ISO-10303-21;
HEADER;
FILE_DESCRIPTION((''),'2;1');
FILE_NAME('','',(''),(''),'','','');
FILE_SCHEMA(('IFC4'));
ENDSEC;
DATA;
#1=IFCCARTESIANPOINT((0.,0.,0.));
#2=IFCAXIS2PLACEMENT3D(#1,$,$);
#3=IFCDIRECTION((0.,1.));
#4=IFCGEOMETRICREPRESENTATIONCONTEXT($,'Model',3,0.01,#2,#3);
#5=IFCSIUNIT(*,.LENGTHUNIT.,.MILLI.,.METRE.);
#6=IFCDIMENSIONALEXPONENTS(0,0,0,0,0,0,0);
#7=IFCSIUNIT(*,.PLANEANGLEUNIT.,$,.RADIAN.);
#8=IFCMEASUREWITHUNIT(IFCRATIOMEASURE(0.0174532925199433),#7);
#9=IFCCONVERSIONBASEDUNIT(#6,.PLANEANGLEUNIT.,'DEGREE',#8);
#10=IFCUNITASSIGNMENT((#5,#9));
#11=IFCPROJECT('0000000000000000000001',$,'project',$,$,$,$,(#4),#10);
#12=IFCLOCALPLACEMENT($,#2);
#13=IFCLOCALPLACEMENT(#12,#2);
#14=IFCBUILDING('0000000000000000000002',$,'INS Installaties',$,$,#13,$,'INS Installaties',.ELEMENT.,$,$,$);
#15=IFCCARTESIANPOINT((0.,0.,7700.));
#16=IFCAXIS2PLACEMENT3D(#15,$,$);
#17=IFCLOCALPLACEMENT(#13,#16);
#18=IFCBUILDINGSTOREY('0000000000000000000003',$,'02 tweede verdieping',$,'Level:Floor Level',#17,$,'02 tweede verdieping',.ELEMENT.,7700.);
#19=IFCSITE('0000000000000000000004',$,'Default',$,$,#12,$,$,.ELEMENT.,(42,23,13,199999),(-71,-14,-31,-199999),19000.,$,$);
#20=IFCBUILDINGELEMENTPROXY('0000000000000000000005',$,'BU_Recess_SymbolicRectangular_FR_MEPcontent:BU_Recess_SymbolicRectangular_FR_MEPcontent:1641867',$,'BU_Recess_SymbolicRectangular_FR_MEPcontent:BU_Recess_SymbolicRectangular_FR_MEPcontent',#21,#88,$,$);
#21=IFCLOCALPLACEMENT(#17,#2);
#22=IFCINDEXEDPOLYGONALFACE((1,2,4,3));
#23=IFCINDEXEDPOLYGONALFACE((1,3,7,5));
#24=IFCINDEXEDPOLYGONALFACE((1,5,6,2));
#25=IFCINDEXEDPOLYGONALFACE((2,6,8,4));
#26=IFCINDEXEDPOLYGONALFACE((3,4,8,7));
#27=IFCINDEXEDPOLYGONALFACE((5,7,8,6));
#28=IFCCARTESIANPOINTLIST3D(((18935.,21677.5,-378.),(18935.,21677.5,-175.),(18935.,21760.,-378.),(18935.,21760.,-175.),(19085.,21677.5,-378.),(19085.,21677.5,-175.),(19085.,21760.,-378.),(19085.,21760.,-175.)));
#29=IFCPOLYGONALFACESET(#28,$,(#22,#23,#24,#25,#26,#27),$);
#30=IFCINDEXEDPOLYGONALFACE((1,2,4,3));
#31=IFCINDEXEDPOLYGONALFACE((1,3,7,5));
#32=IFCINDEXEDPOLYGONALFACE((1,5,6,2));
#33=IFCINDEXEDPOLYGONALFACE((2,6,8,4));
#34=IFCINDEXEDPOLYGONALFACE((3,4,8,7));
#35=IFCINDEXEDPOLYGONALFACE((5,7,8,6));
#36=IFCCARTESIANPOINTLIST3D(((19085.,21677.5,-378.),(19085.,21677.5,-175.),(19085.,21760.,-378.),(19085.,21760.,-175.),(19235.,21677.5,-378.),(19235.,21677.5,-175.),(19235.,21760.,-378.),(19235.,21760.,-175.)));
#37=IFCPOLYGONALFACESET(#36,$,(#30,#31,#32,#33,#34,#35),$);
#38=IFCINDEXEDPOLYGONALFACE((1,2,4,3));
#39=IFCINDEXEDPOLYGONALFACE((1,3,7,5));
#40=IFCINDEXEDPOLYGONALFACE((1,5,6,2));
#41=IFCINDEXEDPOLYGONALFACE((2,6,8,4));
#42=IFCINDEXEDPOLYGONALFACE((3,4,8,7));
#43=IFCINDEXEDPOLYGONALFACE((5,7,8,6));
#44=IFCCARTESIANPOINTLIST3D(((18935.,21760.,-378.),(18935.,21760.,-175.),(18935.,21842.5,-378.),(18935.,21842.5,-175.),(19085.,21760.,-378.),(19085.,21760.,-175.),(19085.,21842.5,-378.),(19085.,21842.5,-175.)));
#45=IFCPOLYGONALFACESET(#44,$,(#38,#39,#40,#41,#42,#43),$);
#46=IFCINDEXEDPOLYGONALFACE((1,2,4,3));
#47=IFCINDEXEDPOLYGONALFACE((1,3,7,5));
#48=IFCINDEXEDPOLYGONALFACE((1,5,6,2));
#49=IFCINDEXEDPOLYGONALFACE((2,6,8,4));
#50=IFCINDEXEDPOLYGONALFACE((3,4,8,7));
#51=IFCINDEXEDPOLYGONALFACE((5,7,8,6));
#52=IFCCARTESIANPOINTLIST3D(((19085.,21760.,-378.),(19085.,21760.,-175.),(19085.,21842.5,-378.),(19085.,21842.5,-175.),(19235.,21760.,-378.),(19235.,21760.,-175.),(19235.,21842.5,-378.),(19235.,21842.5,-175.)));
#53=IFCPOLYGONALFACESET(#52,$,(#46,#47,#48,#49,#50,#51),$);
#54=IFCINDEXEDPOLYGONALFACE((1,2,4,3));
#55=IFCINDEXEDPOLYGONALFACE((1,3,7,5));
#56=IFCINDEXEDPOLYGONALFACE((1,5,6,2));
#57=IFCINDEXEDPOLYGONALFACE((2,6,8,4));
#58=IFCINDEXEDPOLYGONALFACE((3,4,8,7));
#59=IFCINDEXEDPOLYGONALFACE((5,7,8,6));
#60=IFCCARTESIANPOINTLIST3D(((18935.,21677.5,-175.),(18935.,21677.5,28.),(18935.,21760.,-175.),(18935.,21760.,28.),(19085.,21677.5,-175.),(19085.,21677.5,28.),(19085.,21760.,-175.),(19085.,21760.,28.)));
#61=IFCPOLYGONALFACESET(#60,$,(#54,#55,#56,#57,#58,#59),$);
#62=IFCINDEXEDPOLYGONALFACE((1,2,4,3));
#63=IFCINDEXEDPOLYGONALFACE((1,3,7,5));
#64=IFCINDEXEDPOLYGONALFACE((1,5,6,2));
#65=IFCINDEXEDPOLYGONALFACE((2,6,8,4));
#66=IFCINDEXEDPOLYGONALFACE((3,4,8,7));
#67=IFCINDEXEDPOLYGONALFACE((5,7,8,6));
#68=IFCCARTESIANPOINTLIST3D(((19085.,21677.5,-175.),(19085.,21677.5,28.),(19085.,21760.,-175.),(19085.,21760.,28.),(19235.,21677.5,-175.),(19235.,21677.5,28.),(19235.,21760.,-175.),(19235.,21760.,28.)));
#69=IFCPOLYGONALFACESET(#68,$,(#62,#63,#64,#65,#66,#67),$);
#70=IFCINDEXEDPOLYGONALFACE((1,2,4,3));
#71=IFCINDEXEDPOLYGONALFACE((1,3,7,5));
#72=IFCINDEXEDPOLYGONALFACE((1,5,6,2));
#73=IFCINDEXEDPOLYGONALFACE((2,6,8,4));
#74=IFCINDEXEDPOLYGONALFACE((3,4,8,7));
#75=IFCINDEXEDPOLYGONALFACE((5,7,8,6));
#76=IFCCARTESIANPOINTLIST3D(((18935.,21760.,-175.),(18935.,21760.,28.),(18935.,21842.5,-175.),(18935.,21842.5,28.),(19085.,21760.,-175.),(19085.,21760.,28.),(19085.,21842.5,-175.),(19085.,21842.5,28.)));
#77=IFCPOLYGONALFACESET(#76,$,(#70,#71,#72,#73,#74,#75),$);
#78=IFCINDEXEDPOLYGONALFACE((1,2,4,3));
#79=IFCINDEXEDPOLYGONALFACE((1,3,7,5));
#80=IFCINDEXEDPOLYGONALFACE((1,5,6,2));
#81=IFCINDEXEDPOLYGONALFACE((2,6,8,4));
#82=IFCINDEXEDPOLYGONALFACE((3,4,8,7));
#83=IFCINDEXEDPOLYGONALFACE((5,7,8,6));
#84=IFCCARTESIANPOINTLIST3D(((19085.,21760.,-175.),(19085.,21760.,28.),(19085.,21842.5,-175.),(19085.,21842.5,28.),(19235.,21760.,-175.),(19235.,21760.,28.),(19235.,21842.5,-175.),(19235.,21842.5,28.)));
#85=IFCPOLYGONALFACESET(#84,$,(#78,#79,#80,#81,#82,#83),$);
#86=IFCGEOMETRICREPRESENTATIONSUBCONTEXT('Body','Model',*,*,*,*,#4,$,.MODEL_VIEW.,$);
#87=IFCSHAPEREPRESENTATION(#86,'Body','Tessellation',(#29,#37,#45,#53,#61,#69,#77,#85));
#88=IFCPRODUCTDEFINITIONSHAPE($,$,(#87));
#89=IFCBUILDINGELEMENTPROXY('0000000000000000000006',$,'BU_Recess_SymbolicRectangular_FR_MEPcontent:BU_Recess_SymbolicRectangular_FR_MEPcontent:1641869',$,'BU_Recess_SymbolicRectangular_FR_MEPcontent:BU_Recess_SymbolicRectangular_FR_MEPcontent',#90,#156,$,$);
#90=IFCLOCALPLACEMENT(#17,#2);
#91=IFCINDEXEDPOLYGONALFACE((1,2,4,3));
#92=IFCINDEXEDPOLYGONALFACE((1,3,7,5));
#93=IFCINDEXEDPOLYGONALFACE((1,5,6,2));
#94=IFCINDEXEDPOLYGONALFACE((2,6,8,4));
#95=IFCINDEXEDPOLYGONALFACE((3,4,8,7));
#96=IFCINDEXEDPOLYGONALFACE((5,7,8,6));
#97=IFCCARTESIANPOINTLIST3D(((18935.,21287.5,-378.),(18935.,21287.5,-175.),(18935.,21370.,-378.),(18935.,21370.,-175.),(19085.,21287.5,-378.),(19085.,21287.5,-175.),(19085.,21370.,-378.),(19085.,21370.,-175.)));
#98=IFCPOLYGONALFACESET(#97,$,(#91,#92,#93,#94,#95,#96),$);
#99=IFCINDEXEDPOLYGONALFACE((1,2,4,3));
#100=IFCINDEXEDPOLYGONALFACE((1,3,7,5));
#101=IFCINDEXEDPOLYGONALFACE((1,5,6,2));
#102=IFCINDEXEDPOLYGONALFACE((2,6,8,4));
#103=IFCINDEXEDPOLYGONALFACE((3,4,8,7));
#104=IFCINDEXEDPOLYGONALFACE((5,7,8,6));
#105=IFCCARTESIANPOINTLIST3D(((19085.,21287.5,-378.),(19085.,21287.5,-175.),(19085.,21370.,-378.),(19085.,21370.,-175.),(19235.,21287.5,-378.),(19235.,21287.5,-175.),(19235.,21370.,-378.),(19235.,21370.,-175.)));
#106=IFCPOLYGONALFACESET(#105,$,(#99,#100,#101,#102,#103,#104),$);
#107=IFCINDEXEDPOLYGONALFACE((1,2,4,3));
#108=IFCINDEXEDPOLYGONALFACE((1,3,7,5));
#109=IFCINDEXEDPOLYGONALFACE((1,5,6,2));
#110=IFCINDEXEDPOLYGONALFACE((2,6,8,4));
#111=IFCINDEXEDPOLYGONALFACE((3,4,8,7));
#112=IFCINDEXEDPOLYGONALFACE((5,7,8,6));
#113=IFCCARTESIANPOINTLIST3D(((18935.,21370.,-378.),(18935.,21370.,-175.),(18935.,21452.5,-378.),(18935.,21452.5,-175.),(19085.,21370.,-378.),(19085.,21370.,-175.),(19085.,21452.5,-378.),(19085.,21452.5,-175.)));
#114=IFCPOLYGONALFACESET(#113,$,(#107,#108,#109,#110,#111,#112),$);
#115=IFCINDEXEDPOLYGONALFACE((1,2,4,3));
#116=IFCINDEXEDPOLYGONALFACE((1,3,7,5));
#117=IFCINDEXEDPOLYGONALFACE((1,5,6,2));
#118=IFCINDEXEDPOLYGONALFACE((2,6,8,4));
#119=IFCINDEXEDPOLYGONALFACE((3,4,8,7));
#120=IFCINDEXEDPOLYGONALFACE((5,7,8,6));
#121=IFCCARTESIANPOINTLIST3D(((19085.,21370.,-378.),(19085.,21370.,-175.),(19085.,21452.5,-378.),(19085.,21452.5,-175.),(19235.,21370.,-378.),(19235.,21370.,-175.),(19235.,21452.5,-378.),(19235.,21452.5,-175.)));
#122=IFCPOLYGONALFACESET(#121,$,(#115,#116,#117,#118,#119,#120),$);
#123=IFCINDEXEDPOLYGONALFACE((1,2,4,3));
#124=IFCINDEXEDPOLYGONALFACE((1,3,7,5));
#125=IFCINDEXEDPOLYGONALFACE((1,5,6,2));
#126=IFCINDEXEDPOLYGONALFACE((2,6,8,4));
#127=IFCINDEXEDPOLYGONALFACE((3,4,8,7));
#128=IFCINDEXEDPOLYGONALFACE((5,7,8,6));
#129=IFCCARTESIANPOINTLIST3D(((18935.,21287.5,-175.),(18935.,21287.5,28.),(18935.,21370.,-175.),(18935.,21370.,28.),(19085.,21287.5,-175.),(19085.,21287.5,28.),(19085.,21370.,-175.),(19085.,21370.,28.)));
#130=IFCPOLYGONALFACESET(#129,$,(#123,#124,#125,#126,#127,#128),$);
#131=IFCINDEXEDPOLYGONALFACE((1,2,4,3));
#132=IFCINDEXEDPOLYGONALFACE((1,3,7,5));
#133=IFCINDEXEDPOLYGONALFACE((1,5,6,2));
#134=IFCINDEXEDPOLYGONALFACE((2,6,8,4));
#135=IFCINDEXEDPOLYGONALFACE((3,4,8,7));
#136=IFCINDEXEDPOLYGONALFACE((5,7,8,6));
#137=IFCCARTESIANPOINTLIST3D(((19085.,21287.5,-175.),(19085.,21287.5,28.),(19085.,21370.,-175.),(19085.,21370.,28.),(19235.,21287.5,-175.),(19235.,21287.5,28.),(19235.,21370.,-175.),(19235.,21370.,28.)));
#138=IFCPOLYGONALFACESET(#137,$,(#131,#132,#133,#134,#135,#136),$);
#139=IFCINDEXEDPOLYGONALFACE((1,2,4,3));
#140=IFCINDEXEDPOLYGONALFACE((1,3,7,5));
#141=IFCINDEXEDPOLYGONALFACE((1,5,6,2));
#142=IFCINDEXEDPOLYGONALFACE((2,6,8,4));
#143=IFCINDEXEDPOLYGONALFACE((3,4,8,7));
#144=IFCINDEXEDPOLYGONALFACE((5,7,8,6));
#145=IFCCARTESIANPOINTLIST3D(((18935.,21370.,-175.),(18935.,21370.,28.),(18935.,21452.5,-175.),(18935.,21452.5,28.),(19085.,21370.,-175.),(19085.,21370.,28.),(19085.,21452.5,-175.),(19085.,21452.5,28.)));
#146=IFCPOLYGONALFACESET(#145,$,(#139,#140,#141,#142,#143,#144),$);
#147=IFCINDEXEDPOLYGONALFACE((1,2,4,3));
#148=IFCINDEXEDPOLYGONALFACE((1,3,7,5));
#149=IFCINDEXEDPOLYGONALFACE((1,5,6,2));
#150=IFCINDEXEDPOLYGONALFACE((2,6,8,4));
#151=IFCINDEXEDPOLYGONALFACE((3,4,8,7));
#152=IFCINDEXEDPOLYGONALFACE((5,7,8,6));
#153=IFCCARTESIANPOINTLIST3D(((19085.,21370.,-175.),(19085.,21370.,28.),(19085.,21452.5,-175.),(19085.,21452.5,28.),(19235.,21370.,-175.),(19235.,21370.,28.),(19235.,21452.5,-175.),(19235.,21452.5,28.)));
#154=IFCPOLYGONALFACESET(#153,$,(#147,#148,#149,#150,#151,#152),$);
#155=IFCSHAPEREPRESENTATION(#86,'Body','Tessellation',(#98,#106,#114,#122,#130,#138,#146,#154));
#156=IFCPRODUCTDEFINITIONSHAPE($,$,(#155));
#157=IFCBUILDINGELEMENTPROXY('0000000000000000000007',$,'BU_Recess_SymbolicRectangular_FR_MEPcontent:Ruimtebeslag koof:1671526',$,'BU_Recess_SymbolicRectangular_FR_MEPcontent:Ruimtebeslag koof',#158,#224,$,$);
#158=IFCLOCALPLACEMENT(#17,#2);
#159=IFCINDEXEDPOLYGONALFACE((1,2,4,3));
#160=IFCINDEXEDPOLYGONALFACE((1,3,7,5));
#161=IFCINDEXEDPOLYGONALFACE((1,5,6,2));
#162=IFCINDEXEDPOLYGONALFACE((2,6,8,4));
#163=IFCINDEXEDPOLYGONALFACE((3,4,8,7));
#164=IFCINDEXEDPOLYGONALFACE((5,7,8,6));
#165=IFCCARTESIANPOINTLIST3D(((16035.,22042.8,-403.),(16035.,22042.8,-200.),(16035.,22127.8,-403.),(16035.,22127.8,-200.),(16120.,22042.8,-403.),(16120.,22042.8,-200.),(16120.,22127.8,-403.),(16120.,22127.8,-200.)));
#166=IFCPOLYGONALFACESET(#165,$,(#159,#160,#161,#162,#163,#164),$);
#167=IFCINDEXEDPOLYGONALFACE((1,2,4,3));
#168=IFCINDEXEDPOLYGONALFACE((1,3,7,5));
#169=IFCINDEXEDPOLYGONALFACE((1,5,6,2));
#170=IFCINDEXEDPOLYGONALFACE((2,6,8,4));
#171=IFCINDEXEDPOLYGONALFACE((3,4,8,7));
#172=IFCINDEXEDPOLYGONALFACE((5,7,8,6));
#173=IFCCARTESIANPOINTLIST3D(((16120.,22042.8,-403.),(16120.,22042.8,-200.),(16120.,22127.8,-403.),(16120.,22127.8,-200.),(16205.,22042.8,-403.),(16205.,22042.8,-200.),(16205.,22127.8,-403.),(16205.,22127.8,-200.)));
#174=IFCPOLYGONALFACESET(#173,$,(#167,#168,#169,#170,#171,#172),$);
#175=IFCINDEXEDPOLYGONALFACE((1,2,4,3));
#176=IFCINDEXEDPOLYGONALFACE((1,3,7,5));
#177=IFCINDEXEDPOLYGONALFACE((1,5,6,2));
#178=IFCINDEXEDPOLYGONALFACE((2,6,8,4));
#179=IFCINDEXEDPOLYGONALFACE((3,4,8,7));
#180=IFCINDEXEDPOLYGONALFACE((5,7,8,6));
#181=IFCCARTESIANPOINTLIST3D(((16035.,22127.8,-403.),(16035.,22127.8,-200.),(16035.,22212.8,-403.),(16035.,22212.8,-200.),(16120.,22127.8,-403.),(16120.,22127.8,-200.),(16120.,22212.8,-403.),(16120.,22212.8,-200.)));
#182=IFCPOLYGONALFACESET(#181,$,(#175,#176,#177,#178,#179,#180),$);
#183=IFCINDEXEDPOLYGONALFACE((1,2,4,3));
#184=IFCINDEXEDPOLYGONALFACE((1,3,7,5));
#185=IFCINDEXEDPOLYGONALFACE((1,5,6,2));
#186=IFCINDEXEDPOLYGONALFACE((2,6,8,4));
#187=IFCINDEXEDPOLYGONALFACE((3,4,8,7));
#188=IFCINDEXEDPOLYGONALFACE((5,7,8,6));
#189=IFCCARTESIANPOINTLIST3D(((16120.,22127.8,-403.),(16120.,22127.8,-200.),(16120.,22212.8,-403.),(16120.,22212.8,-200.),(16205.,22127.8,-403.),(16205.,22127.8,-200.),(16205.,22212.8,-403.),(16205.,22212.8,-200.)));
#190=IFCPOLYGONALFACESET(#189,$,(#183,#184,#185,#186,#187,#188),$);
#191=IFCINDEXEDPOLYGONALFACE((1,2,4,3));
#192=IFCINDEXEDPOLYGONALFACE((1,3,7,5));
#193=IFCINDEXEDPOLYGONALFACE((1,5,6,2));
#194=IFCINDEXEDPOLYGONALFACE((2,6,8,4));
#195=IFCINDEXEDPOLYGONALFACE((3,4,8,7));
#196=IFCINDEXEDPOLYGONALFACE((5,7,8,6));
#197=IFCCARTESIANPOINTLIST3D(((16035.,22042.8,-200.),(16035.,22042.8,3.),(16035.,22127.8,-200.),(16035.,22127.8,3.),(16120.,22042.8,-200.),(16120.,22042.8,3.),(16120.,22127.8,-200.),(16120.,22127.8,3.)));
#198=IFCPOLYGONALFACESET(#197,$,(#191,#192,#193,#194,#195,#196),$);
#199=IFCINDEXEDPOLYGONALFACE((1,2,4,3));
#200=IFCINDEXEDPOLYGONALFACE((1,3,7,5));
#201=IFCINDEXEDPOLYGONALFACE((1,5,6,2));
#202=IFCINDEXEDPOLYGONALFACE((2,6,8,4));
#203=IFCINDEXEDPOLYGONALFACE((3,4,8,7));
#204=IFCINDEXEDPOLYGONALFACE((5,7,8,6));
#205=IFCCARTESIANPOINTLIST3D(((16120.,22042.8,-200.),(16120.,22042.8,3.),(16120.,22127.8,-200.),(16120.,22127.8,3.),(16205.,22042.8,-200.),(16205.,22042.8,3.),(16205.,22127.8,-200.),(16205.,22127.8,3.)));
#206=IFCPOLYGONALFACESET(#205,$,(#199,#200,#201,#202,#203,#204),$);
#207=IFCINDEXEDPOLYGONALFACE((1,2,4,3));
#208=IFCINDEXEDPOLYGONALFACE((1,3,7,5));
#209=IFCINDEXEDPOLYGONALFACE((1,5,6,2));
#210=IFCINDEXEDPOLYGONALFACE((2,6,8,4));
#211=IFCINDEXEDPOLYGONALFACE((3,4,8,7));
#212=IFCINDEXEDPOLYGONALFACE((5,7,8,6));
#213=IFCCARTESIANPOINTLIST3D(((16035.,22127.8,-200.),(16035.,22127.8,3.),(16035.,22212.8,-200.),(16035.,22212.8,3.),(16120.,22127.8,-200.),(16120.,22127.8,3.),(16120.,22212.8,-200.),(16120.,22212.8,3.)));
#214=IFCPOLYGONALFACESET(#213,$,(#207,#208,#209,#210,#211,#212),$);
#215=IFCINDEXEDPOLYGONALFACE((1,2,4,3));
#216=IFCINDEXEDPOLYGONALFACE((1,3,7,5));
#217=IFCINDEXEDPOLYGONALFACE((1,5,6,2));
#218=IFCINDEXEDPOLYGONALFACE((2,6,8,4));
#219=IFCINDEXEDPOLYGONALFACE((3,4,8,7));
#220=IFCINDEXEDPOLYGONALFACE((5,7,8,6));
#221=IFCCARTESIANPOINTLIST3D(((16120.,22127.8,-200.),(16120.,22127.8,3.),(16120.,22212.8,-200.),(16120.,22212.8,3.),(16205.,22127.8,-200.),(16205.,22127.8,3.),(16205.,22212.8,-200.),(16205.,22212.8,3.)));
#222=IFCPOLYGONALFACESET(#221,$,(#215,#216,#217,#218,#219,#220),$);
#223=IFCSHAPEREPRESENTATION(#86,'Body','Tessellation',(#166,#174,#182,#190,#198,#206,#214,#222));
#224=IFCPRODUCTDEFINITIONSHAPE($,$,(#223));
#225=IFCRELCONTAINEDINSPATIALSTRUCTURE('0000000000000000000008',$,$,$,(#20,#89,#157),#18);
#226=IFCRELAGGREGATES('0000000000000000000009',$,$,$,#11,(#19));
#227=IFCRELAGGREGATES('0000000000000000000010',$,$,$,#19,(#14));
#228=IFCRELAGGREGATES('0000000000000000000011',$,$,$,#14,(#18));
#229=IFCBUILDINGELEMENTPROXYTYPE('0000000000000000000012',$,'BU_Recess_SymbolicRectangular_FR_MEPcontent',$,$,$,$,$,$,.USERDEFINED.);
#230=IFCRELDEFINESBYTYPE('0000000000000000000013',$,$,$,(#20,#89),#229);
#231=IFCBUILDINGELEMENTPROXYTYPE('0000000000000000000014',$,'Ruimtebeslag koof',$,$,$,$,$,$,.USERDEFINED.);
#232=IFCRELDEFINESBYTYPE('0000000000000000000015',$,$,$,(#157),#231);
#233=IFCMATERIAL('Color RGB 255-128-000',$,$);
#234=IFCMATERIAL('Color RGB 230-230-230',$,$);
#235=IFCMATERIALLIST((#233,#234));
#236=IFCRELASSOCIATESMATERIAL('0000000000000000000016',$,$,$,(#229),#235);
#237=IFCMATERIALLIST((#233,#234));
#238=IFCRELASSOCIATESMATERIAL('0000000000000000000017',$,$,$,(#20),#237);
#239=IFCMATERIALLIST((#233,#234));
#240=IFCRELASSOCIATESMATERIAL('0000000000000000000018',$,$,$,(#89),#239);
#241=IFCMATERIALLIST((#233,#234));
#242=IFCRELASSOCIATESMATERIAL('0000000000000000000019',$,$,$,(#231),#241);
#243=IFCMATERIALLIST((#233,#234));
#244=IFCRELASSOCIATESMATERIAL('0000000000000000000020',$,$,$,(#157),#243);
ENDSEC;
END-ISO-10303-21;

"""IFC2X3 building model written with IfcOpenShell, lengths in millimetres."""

from ifc_helpers import new_model, entity, si_unit, converted_unit, direction, frame, frame_2d, origin, origin_2d_with_axis, place, context, subcontext, project, spatial, rectangle, extrude, source, transform, mapped, material, material_list, type_object, type_shapes, element, save


model = new_model("IFC2X3")

# Units and contexts
model_context = context("Model", 3, precision=0.01, world=origin(), true_north=direction((0.0, 1.0)))
body_context = subcontext(model_context, "Body", "Model", "MODEL_VIEW")
ifc_project = project(units=[si_unit("LENGTHUNIT", "METRE", prefix="MILLI"), converted_unit("PLANEANGLEUNIT", "DEGREE", entity("IfcRatioMeasure", 0.0174532925199433), si_unit("PLANEANGLEUNIT", "RADIAN"), dimensions=[0, 0, 0, 0, 0, 0, 0])], contexts=[model_context])

# Site, building, storey
site_placement = place(None, origin())
site = spatial("IfcSite", under=ifc_project, at=site_placement, Name="Default", CompositionType="ELEMENT", RefLatitude=(42, 23, 13, 199999), RefLongitude=(-71, -14, -31, -199999), RefElevation=19000.0)
building_placement = place(site_placement, origin())
building = spatial("IfcBuilding", under=site, at=building_placement, Name="INS Installaties", LongName="INS Installaties", CompositionType="ELEMENT")
storey_placement = place(building_placement, frame((0.0, 0.0, 7700.0)))
storey = spatial("IfcBuildingStorey", under=building, at=storey_placement, Name="02 tweede verdieping", ObjectType="Level:Floor Level", LongName="02 tweede verdieping", CompositionType="ELEMENT", Elevation=7700.0)

# Building element proxies
ifc_material_1 = material(Name="Color RGB 255-128-000")
ifc_material_2 = material(Name="Color RGB 230-230-230")
ifc_material_list_1 = material_list([ifc_material_1, ifc_material_2])
ifc_material_list_2 = material_list([ifc_material_1, ifc_material_2])
building_element_proxy_type_1 = type_object("IfcBuildingElementProxyType", Name="BU_Recess_SymbolicRectangular_FR_MEPcontent", PredefinedType="USERDEFINED", material=ifc_material_list_2)
shared_shape_1 = source(origin(), body_context, "Body", "SweptSolid", [
    extrude(rectangle(XDim=82.5, YDim=150.0, at=origin_2d_with_axis()), frame((75.0, 41.2, -403.0), z_axis=(0.0, 0.0, 1.0), x_axis=(0.0, -1.0, 0.0)), (0.0, 0.0, 1.0), 203.0),
    extrude(rectangle(XDim=150.0, YDim=82.5, at=frame_2d((0.0, 0.0), x_axis=(1.0, 0.0))), frame((-75.0, 41.2, -403.0), z_axis=(0.0, 0.0, 1.0), x_axis=(-1.0, 0.0, 0.0)), (0.0, 0.0, 1.0), 203.0),
    extrude(rectangle(XDim=150.0, YDim=82.5, at=frame_2d((0.0, 0.0), x_axis=(1.0, 0.0))), frame((75.0, -41.3, -403.0)), (0.0, 0.0, 1.0), 203.0),
    extrude(rectangle(XDim=82.5, YDim=150.0, at=origin_2d_with_axis()), frame((-75.0, -41.3, -403.0), z_axis=(0.0, 0.0, 1.0), x_axis=(0.0, 1.0, 0.0)), (0.0, 0.0, 1.0), 203.0),
    extrude(rectangle(XDim=82.5, YDim=150.0, at=origin_2d_with_axis()), frame((75.0, 41.3, -200.0), z_axis=(0.0, 0.0, 1.0), x_axis=(0.0, -1.0, 0.0)), (0.0, 0.0, 1.0), 203.0),
    extrude(rectangle(XDim=150.0, YDim=82.5, at=frame_2d((0.0, 0.0), x_axis=(1.0, 0.0))), frame((-75.0, 41.3, -200.0), z_axis=(0.0, 0.0, 1.0), x_axis=(-1.0, 0.0, 0.0)), (0.0, 0.0, 1.0), 203.0),
    extrude(rectangle(XDim=150.0, YDim=82.5, at=frame_2d((0.0, 0.0), x_axis=(1.0, 0.0))), frame((75.0, -41.2, -200.0)), (0.0, 0.0, 1.0), 203.0),
    extrude(rectangle(XDim=82.5, YDim=150.0, at=origin_2d_with_axis()), frame((-75.0, -41.2, -200.0), z_axis=(0.0, 0.0, 1.0), x_axis=(0.0, 1.0, 0.0)), (0.0, 0.0, 1.0), 203.0),
])
type_shapes(building_element_proxy_type_1, [shared_shape_1])
proxy_1_placement = place(storey_placement, frame((19085.0, 21760.0, 25.0), z_axis=(0.0, 0.0, 1.0), x_axis=(-1.0, 0.0, 0.0)))
element("IfcBuildingElementProxy", 1, at=proxy_1_placement, inside=storey, type_object=building_element_proxy_type_1, material=ifc_material_list_1, Name="BU_Recess_SymbolicRectangular_FR_MEPcontent:BU_Recess_SymbolicRectangular_FR_MEPcontent:1641867", ObjectType="BU_Recess_SymbolicRectangular_FR_MEPcontent:BU_Recess_SymbolicRectangular_FR_MEPcontent", context=body_context, shape_type="MappedRepresentation", body=[
    mapped(shared_shape_1, transform((0.0, 0.0, 0.0), scale=1.0)),
])
ifc_material_list_3 = material_list([ifc_material_1, ifc_material_2])
proxy_2_placement = place(storey_placement, frame((19085.0, 21370.0, 25.0), z_axis=(0.0, 0.0, 1.0), x_axis=(-1.0, 0.0, 0.0)))
element("IfcBuildingElementProxy", 2, at=proxy_2_placement, inside=storey, type_object=building_element_proxy_type_1, material=ifc_material_list_3, Name="BU_Recess_SymbolicRectangular_FR_MEPcontent:BU_Recess_SymbolicRectangular_FR_MEPcontent:1641869", ObjectType="BU_Recess_SymbolicRectangular_FR_MEPcontent:BU_Recess_SymbolicRectangular_FR_MEPcontent", context=body_context, shape_type="MappedRepresentation", body=[
    mapped(shared_shape_1, transform((0.0, 0.0, 0.0), scale=1.0)),
])
ifc_material_list_4 = material_list([ifc_material_1, ifc_material_2])
ifc_material_list_5 = material_list([ifc_material_1, ifc_material_2])
building_element_proxy_type_2 = type_object("IfcBuildingElementProxyType", Name="Ruimtebeslag koof", PredefinedType="USERDEFINED", material=ifc_material_list_5)
shared_shape_2 = source(origin(), body_context, "Body", "SweptSolid", [
    extrude(rectangle(XDim=85.0, YDim=85.0, at=origin_2d_with_axis()), frame((42.5, 42.5, -403.0), z_axis=(0.0, 0.0, 1.0), x_axis=(0.0, -1.0, 0.0)), (0.0, 0.0, 1.0), 203.0),
    extrude(rectangle(XDim=85.0, YDim=85.0, at=origin_2d_with_axis()), frame((-42.5, 42.5, -403.0), z_axis=(0.0, 0.0, 1.0), x_axis=(-1.0, 0.0, 0.0)), (0.0, 0.0, 1.0), 203.0),
    extrude(rectangle(XDim=85.0, YDim=85.0, at=frame_2d((0.0, 0.0), x_axis=(1.0, 0.0))), frame((42.5, -42.5, -403.0)), (0.0, 0.0, 1.0), 203.0),
    extrude(rectangle(XDim=85.0, YDim=85.0, at=origin_2d_with_axis()), frame((-42.5, -42.5, -403.0), z_axis=(0.0, 0.0, 1.0), x_axis=(0.0, 1.0, 0.0)), (0.0, 0.0, 1.0), 203.0),
    extrude(rectangle(XDim=85.0, YDim=85.0, at=origin_2d_with_axis()), frame((42.5, 42.5, -200.0), z_axis=(0.0, 0.0, 1.0), x_axis=(0.0, -1.0, 0.0)), (0.0, 0.0, 1.0), 203.0),
    extrude(rectangle(XDim=85.0, YDim=85.0, at=frame_2d((0.0, 0.0), x_axis=(1.0, 0.0))), frame((-42.5, 42.5, -200.0), z_axis=(0.0, 0.0, 1.0), x_axis=(-1.0, 0.0, 0.0)), (0.0, 0.0, 1.0), 203.0),
    extrude(rectangle(XDim=85.0, YDim=85.0, at=frame_2d((0.0, 0.0), x_axis=(1.0, 0.0))), frame((42.5, -42.5, -200.0)), (0.0, 0.0, 1.0), 203.0),
    extrude(rectangle(XDim=85.0, YDim=85.0, at=origin_2d_with_axis()), frame((-42.5, -42.5, -200.0), z_axis=(0.0, 0.0, 1.0), x_axis=(0.0, 1.0, 0.0)), (0.0, 0.0, 1.0), 203.0),
])
type_shapes(building_element_proxy_type_2, [shared_shape_2])
proxy_3_placement = place(storey_placement, frame((16120.0, 22127.8, 0.0), z_axis=(0.0, 0.0, 1.0), x_axis=(-1.0, 0.0, 0.0)))
element("IfcBuildingElementProxy", 3, at=proxy_3_placement, inside=storey, type_object=building_element_proxy_type_2, material=ifc_material_list_4, Name="BU_Recess_SymbolicRectangular_FR_MEPcontent:Ruimtebeslag koof:1671526", ObjectType="BU_Recess_SymbolicRectangular_FR_MEPcontent:Ruimtebeslag koof", context=body_context, shape_type="MappedRepresentation", body=[
    mapped(shared_shape_2, transform((0.0, 0.0, 0.0), scale=1.0)),
])

save(model, "model.ifc")
